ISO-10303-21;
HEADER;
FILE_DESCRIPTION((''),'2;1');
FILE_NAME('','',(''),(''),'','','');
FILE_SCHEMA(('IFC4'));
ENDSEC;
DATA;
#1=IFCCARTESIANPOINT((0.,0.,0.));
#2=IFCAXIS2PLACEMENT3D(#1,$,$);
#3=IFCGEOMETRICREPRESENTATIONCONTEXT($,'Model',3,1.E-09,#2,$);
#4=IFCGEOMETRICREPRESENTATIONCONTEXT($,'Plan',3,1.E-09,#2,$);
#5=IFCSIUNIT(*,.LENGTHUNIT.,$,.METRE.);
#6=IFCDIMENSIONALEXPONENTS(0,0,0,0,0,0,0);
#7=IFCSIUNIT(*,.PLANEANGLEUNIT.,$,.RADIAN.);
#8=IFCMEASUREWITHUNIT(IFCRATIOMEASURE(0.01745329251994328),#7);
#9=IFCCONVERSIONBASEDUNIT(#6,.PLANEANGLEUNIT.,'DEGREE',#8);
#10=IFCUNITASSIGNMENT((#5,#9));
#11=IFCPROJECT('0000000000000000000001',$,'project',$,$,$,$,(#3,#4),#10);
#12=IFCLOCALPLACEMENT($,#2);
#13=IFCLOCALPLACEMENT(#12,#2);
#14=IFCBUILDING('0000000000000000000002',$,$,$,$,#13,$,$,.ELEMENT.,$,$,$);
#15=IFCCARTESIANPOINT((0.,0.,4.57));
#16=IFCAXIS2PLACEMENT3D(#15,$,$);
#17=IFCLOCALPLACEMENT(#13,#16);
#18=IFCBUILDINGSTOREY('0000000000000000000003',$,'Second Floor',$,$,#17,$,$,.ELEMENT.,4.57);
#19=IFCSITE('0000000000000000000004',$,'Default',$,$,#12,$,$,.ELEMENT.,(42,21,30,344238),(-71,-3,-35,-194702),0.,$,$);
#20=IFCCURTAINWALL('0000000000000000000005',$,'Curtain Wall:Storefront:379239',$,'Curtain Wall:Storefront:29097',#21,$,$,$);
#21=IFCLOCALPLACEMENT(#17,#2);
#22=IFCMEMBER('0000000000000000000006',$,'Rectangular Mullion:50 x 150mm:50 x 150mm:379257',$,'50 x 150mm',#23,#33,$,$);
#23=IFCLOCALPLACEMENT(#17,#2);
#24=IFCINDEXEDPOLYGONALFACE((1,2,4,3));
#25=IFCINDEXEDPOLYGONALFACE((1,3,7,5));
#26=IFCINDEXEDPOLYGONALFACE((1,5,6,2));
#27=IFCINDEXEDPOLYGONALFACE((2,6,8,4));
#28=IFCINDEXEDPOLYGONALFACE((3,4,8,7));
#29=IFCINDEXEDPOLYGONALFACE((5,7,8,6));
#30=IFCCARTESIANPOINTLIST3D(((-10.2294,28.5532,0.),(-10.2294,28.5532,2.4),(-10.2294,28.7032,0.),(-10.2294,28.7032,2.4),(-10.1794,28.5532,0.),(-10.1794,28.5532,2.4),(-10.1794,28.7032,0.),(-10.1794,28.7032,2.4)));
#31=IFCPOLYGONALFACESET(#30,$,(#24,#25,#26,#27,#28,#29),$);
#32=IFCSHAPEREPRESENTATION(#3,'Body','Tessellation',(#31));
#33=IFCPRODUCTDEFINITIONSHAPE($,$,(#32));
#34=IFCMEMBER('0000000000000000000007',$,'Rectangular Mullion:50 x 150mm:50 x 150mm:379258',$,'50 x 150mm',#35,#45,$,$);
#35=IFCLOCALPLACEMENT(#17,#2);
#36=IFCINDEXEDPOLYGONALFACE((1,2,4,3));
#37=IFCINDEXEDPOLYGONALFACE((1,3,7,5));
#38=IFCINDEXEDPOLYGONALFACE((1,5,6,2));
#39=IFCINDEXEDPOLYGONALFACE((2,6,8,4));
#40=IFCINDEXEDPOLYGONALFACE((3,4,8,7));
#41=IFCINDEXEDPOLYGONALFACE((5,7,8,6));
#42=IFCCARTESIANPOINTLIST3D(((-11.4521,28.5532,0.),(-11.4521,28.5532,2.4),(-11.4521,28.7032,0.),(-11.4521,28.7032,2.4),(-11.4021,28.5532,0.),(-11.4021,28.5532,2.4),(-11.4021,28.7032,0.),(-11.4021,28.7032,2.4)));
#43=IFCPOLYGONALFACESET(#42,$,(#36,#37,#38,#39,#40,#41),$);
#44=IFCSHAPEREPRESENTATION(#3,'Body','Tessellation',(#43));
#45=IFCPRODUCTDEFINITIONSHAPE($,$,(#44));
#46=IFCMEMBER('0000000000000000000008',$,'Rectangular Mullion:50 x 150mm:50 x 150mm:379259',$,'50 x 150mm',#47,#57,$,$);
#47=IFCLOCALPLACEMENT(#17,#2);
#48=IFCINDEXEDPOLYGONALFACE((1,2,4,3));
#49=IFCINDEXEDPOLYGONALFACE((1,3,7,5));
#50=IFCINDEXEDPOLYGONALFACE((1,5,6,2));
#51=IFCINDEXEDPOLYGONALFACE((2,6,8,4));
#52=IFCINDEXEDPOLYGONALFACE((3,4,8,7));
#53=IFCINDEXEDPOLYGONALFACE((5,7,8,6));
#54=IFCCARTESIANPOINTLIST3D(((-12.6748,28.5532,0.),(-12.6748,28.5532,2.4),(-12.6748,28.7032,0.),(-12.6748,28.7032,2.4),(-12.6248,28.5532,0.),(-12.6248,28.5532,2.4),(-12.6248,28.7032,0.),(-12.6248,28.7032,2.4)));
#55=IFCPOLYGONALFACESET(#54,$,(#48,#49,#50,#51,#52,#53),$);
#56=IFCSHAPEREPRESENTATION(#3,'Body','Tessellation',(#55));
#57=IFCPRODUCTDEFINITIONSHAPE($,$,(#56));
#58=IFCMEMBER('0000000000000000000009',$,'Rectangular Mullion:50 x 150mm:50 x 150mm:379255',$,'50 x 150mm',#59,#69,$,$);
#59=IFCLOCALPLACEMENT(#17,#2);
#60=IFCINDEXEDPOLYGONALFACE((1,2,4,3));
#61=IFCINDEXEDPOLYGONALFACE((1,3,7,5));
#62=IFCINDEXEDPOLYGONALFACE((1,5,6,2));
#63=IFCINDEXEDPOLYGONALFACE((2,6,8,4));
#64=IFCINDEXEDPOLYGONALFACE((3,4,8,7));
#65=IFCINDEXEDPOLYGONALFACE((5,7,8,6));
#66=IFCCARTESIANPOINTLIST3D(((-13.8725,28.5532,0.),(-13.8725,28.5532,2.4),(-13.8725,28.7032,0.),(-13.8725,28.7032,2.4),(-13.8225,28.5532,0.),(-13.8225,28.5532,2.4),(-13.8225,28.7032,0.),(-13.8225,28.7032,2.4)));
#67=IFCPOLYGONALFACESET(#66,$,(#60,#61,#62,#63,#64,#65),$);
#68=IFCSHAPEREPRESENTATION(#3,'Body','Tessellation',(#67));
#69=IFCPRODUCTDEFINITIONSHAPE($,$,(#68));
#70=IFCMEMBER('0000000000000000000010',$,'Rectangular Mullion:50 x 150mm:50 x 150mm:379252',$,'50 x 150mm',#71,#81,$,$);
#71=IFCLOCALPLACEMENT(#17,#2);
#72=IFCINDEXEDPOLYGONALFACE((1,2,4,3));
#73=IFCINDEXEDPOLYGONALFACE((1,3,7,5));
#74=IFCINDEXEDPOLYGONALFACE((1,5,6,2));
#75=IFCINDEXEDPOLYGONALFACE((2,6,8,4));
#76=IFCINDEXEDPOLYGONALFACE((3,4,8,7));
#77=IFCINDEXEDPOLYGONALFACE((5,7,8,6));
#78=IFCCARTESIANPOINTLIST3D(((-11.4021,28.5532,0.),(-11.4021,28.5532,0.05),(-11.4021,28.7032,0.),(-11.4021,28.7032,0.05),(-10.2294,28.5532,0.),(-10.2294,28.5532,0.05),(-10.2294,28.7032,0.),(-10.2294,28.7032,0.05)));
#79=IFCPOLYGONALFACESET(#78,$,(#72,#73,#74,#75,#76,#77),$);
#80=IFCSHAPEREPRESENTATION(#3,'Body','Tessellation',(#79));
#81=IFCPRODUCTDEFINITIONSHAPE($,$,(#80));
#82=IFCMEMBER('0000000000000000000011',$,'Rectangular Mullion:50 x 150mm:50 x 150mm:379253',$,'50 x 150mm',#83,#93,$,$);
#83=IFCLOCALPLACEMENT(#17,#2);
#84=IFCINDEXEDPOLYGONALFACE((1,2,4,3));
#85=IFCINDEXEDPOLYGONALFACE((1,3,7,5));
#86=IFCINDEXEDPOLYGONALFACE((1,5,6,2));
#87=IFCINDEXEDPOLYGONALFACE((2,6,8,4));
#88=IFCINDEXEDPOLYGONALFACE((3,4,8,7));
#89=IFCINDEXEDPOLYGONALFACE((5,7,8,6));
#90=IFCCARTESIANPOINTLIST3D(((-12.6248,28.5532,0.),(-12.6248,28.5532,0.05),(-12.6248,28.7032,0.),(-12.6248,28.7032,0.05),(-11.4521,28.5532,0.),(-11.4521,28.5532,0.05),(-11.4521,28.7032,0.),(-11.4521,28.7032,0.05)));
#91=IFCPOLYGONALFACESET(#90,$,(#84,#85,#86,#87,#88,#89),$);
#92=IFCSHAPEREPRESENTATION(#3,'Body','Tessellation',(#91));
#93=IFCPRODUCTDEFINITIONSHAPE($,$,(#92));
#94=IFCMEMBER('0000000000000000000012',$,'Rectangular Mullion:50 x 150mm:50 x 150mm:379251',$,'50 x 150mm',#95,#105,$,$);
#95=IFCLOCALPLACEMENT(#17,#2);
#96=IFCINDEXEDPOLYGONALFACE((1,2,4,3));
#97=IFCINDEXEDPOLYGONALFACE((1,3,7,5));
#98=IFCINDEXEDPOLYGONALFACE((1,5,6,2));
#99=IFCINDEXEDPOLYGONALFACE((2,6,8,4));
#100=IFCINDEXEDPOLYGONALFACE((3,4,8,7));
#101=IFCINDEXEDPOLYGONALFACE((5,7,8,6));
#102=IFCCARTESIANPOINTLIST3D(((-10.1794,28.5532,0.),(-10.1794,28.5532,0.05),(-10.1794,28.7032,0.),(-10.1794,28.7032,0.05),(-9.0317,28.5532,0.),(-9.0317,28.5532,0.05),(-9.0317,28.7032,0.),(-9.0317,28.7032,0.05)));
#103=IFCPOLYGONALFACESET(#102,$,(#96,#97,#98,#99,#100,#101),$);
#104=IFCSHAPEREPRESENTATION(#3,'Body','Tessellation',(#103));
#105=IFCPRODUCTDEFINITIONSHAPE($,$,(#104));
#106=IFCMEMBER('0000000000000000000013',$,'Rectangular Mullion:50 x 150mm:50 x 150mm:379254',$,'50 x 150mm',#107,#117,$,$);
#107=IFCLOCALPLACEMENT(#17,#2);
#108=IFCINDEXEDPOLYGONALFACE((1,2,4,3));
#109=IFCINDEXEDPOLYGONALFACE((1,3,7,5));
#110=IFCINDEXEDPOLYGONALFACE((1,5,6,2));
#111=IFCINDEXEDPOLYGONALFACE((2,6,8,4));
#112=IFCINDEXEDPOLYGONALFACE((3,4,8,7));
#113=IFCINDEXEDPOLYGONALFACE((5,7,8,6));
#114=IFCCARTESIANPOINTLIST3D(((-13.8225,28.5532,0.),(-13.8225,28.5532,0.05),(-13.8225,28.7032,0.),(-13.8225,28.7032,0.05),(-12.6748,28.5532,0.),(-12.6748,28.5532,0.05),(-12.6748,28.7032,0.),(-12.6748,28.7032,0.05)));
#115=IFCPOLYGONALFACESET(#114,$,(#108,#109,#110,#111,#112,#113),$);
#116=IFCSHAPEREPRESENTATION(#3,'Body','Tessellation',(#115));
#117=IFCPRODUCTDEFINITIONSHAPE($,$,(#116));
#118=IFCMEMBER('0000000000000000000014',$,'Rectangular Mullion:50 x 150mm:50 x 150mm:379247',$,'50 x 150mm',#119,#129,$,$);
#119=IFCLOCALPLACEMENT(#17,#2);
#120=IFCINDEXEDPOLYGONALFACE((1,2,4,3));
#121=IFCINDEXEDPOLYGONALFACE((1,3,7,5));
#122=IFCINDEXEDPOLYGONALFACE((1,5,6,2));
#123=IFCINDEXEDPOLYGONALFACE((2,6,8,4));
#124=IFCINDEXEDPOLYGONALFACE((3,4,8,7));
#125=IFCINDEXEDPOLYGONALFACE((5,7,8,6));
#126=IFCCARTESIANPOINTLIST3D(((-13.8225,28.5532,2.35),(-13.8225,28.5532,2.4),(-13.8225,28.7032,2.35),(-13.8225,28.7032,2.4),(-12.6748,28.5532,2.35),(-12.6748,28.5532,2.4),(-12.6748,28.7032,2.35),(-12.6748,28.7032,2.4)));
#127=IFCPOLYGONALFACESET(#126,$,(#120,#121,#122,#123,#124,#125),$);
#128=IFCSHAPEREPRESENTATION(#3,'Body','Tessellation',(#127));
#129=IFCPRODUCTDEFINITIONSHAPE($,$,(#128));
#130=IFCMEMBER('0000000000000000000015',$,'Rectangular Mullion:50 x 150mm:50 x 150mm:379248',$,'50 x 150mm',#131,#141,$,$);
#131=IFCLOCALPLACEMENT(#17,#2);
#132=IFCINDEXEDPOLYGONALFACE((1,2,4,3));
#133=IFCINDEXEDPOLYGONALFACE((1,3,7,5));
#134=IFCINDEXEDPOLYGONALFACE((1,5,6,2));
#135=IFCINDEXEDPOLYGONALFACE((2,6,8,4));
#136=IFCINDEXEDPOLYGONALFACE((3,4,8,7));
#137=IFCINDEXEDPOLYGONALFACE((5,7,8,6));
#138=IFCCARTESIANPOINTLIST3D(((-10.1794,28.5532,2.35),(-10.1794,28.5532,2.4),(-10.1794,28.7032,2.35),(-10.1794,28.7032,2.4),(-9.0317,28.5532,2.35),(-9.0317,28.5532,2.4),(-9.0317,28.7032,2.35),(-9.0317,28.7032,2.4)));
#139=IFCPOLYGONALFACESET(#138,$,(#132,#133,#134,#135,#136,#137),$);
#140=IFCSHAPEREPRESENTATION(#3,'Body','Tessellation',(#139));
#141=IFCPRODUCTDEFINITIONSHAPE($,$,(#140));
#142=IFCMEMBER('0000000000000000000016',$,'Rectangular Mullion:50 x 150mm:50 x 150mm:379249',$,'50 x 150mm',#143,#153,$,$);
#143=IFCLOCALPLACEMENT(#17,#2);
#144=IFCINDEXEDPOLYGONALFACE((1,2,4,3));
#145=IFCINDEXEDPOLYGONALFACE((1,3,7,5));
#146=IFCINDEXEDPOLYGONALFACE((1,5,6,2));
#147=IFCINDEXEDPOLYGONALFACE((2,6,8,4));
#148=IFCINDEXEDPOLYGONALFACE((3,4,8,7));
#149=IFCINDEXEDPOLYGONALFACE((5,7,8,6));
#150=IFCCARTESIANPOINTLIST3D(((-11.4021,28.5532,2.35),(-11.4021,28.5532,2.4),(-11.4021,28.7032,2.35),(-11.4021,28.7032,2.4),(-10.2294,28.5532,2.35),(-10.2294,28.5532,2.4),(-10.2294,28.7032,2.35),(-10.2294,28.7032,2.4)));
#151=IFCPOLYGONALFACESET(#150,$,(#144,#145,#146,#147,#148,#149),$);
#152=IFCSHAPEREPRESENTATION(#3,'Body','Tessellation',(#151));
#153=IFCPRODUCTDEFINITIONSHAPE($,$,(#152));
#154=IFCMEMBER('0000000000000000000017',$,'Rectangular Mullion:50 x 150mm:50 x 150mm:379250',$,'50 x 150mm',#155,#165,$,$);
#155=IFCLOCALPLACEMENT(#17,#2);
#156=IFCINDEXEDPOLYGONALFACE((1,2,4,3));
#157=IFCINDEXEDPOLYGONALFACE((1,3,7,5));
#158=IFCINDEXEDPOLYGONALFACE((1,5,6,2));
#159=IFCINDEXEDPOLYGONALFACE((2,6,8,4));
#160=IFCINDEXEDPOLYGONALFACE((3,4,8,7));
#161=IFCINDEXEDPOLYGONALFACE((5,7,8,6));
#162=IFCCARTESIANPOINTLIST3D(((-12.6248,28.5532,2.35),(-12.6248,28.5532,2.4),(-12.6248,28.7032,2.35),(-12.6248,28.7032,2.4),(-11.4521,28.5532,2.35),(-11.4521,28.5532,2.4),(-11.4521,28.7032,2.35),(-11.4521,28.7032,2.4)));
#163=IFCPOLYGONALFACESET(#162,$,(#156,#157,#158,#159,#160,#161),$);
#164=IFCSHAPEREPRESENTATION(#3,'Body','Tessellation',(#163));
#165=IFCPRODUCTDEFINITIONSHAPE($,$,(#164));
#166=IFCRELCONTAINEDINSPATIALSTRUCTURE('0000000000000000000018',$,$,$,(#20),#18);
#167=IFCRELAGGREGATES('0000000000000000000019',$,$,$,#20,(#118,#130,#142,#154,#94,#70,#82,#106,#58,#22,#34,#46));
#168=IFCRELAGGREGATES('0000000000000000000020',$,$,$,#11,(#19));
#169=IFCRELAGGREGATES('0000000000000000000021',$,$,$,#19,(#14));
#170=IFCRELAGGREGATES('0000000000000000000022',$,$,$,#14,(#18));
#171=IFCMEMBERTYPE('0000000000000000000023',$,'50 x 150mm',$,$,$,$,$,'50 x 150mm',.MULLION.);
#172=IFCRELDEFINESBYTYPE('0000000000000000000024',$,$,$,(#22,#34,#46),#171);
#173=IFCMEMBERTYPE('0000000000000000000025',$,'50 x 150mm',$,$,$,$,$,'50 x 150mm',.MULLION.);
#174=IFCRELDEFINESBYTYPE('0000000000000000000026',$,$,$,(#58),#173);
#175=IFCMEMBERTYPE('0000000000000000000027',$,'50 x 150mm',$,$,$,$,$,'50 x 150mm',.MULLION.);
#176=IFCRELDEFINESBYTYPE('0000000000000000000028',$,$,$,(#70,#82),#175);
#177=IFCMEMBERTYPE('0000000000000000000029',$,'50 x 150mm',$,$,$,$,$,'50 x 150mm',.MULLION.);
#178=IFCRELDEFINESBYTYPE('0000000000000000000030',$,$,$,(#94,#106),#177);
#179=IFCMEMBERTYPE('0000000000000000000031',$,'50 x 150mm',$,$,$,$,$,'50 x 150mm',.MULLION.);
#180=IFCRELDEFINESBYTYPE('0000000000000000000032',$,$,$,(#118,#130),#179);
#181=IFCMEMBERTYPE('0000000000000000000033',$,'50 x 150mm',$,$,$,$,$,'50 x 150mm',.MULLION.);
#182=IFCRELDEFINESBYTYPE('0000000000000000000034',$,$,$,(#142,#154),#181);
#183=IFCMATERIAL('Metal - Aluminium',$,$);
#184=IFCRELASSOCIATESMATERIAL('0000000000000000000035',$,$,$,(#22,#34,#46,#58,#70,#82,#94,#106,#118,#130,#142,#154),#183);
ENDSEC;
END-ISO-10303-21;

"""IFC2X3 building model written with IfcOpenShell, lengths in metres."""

from ifc_helpers import new_model, entity, si_unit, converted_unit, frame, origin, origin_2d_with_axis, place, context, project, spatial, rectangle, extrude, source, transform, mapped, material, type_object, type_shapes, element, aggregate, save


model = new_model("IFC2X3")

# Units and contexts
model_context = context("Model", 3, precision=1e-09, world=origin())
plan_context = context("Plan", 3, precision=1e-09, world=origin())
ifc_project = project(units=[si_unit("LENGTHUNIT", "METRE"), converted_unit("PLANEANGLEUNIT", "DEGREE", entity("IfcRatioMeasure", 0.01745329251994328), si_unit("PLANEANGLEUNIT", "RADIAN"), dimensions=[0, 0, 0, 0, 0, 0, 0])], contexts=[model_context, plan_context])

# Site, building, storey
site_placement = place(None, origin())
site = spatial("IfcSite", under=ifc_project, at=site_placement, Name="Default", CompositionType="ELEMENT", RefLatitude=(42, 21, 30, 344238), RefLongitude=(-71, -3, -35, -194702), RefElevation=0.0)
building_placement = place(site_placement, origin())
building = spatial("IfcBuilding", under=site, at=building_placement, CompositionType="ELEMENT")
storey_placement = place(building_placement, frame((0.0, 0.0, 4.57)))
storey = spatial("IfcBuildingStorey", under=building, at=storey_placement, Name="Second Floor", CompositionType="ELEMENT", Elevation=4.57)

# Curtain wall, members
curtain_wall_placement = place(storey_placement, origin())
curtain_wall = element("IfcCurtainWall", 1, at=curtain_wall_placement, inside=storey, Name="Curtain Wall:Storefront:379239", ObjectType="Curtain Wall:Storefront:29097")
ifc_material_1 = material(Name="Metal - Aluminium")
member_type_1 = type_object("IfcMemberType", Name="50 x 150mm", ElementType="50 x 150mm", PredefinedType="MULLION")
shared_shape_1 = source(origin(), model_context, "Body", "SweptSolid", [
    extrude(rectangle(XDim=0.05, YDim=0.15, at=origin_2d_with_axis()), frame((0.0, 0.0, -2.4), z_axis=(0.0, 0.0, 1.0), x_axis=(-1.0, 0.0, 0.0)), (0.0, 0.0, 1.0), 2.4),
])
type_shapes(member_type_1, [shared_shape_1])
member_1_placement = place(storey_placement, frame((-10.2044, 28.6282, 0.0), z_axis=(0.0, 0.0, -1.0), x_axis=(-1.0, 0.0, 0.0)))
member_1 = element("IfcMember", 2, at=member_1_placement, type_object=member_type_1, material=ifc_material_1, Name="Rectangular Mullion:50 x 150mm:50 x 150mm:379257", ObjectType="50 x 150mm", context=model_context, shape_type="MappedRepresentation", body=[
    mapped(shared_shape_1, transform((0.0, 0.0, 0.0), scale=1.0)),
])
member_2_placement = place(storey_placement, frame((-11.4271, 28.6282, 0.0), z_axis=(0.0, 0.0, -1.0), x_axis=(-1.0, 0.0, 0.0)))
member_2 = element("IfcMember", 3, at=member_2_placement, type_object=member_type_1, material=ifc_material_1, Name="Rectangular Mullion:50 x 150mm:50 x 150mm:379258", ObjectType="50 x 150mm", context=model_context, shape_type="MappedRepresentation", body=[
    mapped(shared_shape_1, transform((0.0, 0.0, 0.0), scale=1.0)),
])
member_3_placement = place(storey_placement, frame((-12.6498, 28.6282, 0.0), z_axis=(0.0, 0.0, -1.0), x_axis=(-1.0, 0.0, 0.0)))
member_3 = element("IfcMember", 4, at=member_3_placement, type_object=member_type_1, material=ifc_material_1, Name="Rectangular Mullion:50 x 150mm:50 x 150mm:379259", ObjectType="50 x 150mm", context=model_context, shape_type="MappedRepresentation", body=[
    mapped(shared_shape_1, transform((0.0, 0.0, 0.0), scale=1.0)),
])
member_type_2 = type_object("IfcMemberType", Name="50 x 150mm", ElementType="50 x 150mm", PredefinedType="MULLION")
shared_shape_2 = source(origin(), model_context, "Body", "SweptSolid", [
    extrude(rectangle(XDim=0.05, YDim=0.15, at=origin_2d_with_axis()), frame((-0.025, 0.0, -2.4), z_axis=(0.0, 0.0, 1.0), x_axis=(-1.0, 0.0, 0.0)), (0.0, 0.0, 1.0), 2.4),
])
type_shapes(member_type_2, [shared_shape_2])
member_4_placement = place(storey_placement, frame((-13.8725, 28.6282, 0.0), z_axis=(0.0, 0.0, -1.0), x_axis=(-1.0, 0.0, 0.0)))
member_4 = element("IfcMember", 5, at=member_4_placement, type_object=member_type_2, material=ifc_material_1, Name="Rectangular Mullion:50 x 150mm:50 x 150mm:379255", ObjectType="50 x 150mm", context=model_context, shape_type="MappedRepresentation", body=[
    mapped(shared_shape_2, transform((0.0, 0.0, 0.0), scale=1.0)),
])
member_type_3 = type_object("IfcMemberType", Name="50 x 150mm", ElementType="50 x 150mm", PredefinedType="MULLION")
shared_shape_3 = source(origin(), model_context, "Body", "SweptSolid", [
    extrude(rectangle(XDim=0.05, YDim=0.15, at=origin_2d_with_axis()), frame((-0.025, 0.0, -1.1727), z_axis=(0.0, 0.0, 1.0), x_axis=(-1.0, 0.0, 0.0)), (0.0, 0.0, 1.0), 1.1727),
])
type_shapes(member_type_3, [shared_shape_3])
member_5_placement = place(storey_placement, frame((-10.2294, 28.6282, 0.0), z_axis=(1.0, 0.0, 0.0), x_axis=(0.0, 0.0, -1.0)))
member_5 = element("IfcMember", 6, at=member_5_placement, type_object=member_type_3, material=ifc_material_1, Name="Rectangular Mullion:50 x 150mm:50 x 150mm:379252", ObjectType="50 x 150mm", context=model_context, shape_type="MappedRepresentation", body=[
    mapped(shared_shape_3, transform((0.0, 0.0, 0.0), scale=1.0)),
])
member_6_placement = place(storey_placement, frame((-11.4521, 28.6282, 0.0), z_axis=(1.0, 0.0, 0.0), x_axis=(0.0, 0.0, -1.0)))
member_6 = element("IfcMember", 7, at=member_6_placement, type_object=member_type_3, material=ifc_material_1, Name="Rectangular Mullion:50 x 150mm:50 x 150mm:379253", ObjectType="50 x 150mm", context=model_context, shape_type="MappedRepresentation", body=[
    mapped(shared_shape_3, transform((0.0, 0.0, 0.0), scale=1.0)),
])
member_type_4 = type_object("IfcMemberType", Name="50 x 150mm", ElementType="50 x 150mm", PredefinedType="MULLION")
shared_shape_4 = source(origin(), model_context, "Body", "SweptSolid", [
    extrude(rectangle(XDim=0.05, YDim=0.15, at=origin_2d_with_axis()), frame((-0.025, 0.0, -1.1477), z_axis=(0.0, 0.0, 1.0), x_axis=(-1.0, 0.0, 0.0)), (0.0, 0.0, 1.0), 1.1477),
])
type_shapes(member_type_4, [shared_shape_4])
member_7_placement = place(storey_placement, frame((-9.0317, 28.6282, 0.0), z_axis=(1.0, 0.0, 0.0), x_axis=(0.0, 0.0, -1.0)))
member_7 = element("IfcMember", 8, at=member_7_placement, type_object=member_type_4, material=ifc_material_1, Name="Rectangular Mullion:50 x 150mm:50 x 150mm:379251", ObjectType="50 x 150mm", context=model_context, shape_type="MappedRepresentation", body=[
    mapped(shared_shape_4, transform((0.0, 0.0, 0.0), scale=1.0)),
])
member_8_placement = place(storey_placement, frame((-12.6748, 28.6282, 0.0), z_axis=(1.0, 0.0, 0.0), x_axis=(0.0, 0.0, -1.0)))
member_8 = element("IfcMember", 9, at=member_8_placement, type_object=member_type_4, material=ifc_material_1, Name="Rectangular Mullion:50 x 150mm:50 x 150mm:379254", ObjectType="50 x 150mm", context=model_context, shape_type="MappedRepresentation", body=[
    mapped(shared_shape_4, transform((0.0, 0.0, 0.0), scale=1.0)),
])
member_type_5 = type_object("IfcMemberType", Name="50 x 150mm", ElementType="50 x 150mm", PredefinedType="MULLION")
shared_shape_5 = source(origin(), model_context, "Body", "SweptSolid", [
    extrude(rectangle(XDim=0.05, YDim=0.15, at=origin_2d_with_axis()), frame((-0.025, 0.0, -1.1477), z_axis=(0.0, 0.0, 1.0), x_axis=(-1.0, 0.0, 0.0)), (0.0, 0.0, 1.0), 1.1477),
])
type_shapes(member_type_5, [shared_shape_5])
member_9_placement = place(storey_placement, frame((-13.8225, 28.6282, 2.4), z_axis=(-1.0, 0.0, 0.0), x_axis=(0.0, 0.0, 1.0)))
member_9 = element("IfcMember", 10, at=member_9_placement, type_object=member_type_5, material=ifc_material_1, Name="Rectangular Mullion:50 x 150mm:50 x 150mm:379247", ObjectType="50 x 150mm", context=model_context, shape_type="MappedRepresentation", body=[
    mapped(shared_shape_5, transform((0.0, 0.0, 0.0), scale=1.0)),
])
member_10_placement = place(storey_placement, frame((-10.1794, 28.6282, 2.4), z_axis=(-1.0, 0.0, 0.0), x_axis=(0.0, 0.0, 1.0)))
member_10 = element("IfcMember", 11, at=member_10_placement, type_object=member_type_5, material=ifc_material_1, Name="Rectangular Mullion:50 x 150mm:50 x 150mm:379248", ObjectType="50 x 150mm", context=model_context, shape_type="MappedRepresentation", body=[
    mapped(shared_shape_5, transform((0.0, 0.0, 0.0), scale=1.0)),
])
member_type_6 = type_object("IfcMemberType", Name="50 x 150mm", ElementType="50 x 150mm", PredefinedType="MULLION")
shared_shape_6 = source(origin(), model_context, "Body", "SweptSolid", [
    extrude(rectangle(XDim=0.05, YDim=0.15, at=origin_2d_with_axis()), frame((-0.025, 0.0, -1.1727), z_axis=(0.0, 0.0, 1.0), x_axis=(-1.0, 0.0, 0.0)), (0.0, 0.0, 1.0), 1.1727),
])
type_shapes(member_type_6, [shared_shape_6])
member_11_placement = place(storey_placement, frame((-11.4021, 28.6282, 2.4), z_axis=(-1.0, 0.0, 0.0), x_axis=(0.0, 0.0, 1.0)))
member_11 = element("IfcMember", 12, at=member_11_placement, type_object=member_type_6, material=ifc_material_1, Name="Rectangular Mullion:50 x 150mm:50 x 150mm:379249", ObjectType="50 x 150mm", context=model_context, shape_type="MappedRepresentation", body=[
    mapped(shared_shape_6, transform((0.0, 0.0, 0.0), scale=1.0)),
])
member_12_placement = place(storey_placement, frame((-12.6248, 28.6282, 2.4), z_axis=(-1.0, 0.0, 0.0), x_axis=(0.0, 0.0, 1.0)))
member_12 = element("IfcMember", 13, at=member_12_placement, type_object=member_type_6, material=ifc_material_1, Name="Rectangular Mullion:50 x 150mm:50 x 150mm:379250", ObjectType="50 x 150mm", context=model_context, shape_type="MappedRepresentation", body=[
    mapped(shared_shape_6, transform((0.0, 0.0, 0.0), scale=1.0)),
])
aggregate(curtain_wall, [member_9, member_10, member_11, member_12, member_7, member_5, member_6, member_8, member_4, member_1, member_2, member_3])

save(model, "model.ifc")
